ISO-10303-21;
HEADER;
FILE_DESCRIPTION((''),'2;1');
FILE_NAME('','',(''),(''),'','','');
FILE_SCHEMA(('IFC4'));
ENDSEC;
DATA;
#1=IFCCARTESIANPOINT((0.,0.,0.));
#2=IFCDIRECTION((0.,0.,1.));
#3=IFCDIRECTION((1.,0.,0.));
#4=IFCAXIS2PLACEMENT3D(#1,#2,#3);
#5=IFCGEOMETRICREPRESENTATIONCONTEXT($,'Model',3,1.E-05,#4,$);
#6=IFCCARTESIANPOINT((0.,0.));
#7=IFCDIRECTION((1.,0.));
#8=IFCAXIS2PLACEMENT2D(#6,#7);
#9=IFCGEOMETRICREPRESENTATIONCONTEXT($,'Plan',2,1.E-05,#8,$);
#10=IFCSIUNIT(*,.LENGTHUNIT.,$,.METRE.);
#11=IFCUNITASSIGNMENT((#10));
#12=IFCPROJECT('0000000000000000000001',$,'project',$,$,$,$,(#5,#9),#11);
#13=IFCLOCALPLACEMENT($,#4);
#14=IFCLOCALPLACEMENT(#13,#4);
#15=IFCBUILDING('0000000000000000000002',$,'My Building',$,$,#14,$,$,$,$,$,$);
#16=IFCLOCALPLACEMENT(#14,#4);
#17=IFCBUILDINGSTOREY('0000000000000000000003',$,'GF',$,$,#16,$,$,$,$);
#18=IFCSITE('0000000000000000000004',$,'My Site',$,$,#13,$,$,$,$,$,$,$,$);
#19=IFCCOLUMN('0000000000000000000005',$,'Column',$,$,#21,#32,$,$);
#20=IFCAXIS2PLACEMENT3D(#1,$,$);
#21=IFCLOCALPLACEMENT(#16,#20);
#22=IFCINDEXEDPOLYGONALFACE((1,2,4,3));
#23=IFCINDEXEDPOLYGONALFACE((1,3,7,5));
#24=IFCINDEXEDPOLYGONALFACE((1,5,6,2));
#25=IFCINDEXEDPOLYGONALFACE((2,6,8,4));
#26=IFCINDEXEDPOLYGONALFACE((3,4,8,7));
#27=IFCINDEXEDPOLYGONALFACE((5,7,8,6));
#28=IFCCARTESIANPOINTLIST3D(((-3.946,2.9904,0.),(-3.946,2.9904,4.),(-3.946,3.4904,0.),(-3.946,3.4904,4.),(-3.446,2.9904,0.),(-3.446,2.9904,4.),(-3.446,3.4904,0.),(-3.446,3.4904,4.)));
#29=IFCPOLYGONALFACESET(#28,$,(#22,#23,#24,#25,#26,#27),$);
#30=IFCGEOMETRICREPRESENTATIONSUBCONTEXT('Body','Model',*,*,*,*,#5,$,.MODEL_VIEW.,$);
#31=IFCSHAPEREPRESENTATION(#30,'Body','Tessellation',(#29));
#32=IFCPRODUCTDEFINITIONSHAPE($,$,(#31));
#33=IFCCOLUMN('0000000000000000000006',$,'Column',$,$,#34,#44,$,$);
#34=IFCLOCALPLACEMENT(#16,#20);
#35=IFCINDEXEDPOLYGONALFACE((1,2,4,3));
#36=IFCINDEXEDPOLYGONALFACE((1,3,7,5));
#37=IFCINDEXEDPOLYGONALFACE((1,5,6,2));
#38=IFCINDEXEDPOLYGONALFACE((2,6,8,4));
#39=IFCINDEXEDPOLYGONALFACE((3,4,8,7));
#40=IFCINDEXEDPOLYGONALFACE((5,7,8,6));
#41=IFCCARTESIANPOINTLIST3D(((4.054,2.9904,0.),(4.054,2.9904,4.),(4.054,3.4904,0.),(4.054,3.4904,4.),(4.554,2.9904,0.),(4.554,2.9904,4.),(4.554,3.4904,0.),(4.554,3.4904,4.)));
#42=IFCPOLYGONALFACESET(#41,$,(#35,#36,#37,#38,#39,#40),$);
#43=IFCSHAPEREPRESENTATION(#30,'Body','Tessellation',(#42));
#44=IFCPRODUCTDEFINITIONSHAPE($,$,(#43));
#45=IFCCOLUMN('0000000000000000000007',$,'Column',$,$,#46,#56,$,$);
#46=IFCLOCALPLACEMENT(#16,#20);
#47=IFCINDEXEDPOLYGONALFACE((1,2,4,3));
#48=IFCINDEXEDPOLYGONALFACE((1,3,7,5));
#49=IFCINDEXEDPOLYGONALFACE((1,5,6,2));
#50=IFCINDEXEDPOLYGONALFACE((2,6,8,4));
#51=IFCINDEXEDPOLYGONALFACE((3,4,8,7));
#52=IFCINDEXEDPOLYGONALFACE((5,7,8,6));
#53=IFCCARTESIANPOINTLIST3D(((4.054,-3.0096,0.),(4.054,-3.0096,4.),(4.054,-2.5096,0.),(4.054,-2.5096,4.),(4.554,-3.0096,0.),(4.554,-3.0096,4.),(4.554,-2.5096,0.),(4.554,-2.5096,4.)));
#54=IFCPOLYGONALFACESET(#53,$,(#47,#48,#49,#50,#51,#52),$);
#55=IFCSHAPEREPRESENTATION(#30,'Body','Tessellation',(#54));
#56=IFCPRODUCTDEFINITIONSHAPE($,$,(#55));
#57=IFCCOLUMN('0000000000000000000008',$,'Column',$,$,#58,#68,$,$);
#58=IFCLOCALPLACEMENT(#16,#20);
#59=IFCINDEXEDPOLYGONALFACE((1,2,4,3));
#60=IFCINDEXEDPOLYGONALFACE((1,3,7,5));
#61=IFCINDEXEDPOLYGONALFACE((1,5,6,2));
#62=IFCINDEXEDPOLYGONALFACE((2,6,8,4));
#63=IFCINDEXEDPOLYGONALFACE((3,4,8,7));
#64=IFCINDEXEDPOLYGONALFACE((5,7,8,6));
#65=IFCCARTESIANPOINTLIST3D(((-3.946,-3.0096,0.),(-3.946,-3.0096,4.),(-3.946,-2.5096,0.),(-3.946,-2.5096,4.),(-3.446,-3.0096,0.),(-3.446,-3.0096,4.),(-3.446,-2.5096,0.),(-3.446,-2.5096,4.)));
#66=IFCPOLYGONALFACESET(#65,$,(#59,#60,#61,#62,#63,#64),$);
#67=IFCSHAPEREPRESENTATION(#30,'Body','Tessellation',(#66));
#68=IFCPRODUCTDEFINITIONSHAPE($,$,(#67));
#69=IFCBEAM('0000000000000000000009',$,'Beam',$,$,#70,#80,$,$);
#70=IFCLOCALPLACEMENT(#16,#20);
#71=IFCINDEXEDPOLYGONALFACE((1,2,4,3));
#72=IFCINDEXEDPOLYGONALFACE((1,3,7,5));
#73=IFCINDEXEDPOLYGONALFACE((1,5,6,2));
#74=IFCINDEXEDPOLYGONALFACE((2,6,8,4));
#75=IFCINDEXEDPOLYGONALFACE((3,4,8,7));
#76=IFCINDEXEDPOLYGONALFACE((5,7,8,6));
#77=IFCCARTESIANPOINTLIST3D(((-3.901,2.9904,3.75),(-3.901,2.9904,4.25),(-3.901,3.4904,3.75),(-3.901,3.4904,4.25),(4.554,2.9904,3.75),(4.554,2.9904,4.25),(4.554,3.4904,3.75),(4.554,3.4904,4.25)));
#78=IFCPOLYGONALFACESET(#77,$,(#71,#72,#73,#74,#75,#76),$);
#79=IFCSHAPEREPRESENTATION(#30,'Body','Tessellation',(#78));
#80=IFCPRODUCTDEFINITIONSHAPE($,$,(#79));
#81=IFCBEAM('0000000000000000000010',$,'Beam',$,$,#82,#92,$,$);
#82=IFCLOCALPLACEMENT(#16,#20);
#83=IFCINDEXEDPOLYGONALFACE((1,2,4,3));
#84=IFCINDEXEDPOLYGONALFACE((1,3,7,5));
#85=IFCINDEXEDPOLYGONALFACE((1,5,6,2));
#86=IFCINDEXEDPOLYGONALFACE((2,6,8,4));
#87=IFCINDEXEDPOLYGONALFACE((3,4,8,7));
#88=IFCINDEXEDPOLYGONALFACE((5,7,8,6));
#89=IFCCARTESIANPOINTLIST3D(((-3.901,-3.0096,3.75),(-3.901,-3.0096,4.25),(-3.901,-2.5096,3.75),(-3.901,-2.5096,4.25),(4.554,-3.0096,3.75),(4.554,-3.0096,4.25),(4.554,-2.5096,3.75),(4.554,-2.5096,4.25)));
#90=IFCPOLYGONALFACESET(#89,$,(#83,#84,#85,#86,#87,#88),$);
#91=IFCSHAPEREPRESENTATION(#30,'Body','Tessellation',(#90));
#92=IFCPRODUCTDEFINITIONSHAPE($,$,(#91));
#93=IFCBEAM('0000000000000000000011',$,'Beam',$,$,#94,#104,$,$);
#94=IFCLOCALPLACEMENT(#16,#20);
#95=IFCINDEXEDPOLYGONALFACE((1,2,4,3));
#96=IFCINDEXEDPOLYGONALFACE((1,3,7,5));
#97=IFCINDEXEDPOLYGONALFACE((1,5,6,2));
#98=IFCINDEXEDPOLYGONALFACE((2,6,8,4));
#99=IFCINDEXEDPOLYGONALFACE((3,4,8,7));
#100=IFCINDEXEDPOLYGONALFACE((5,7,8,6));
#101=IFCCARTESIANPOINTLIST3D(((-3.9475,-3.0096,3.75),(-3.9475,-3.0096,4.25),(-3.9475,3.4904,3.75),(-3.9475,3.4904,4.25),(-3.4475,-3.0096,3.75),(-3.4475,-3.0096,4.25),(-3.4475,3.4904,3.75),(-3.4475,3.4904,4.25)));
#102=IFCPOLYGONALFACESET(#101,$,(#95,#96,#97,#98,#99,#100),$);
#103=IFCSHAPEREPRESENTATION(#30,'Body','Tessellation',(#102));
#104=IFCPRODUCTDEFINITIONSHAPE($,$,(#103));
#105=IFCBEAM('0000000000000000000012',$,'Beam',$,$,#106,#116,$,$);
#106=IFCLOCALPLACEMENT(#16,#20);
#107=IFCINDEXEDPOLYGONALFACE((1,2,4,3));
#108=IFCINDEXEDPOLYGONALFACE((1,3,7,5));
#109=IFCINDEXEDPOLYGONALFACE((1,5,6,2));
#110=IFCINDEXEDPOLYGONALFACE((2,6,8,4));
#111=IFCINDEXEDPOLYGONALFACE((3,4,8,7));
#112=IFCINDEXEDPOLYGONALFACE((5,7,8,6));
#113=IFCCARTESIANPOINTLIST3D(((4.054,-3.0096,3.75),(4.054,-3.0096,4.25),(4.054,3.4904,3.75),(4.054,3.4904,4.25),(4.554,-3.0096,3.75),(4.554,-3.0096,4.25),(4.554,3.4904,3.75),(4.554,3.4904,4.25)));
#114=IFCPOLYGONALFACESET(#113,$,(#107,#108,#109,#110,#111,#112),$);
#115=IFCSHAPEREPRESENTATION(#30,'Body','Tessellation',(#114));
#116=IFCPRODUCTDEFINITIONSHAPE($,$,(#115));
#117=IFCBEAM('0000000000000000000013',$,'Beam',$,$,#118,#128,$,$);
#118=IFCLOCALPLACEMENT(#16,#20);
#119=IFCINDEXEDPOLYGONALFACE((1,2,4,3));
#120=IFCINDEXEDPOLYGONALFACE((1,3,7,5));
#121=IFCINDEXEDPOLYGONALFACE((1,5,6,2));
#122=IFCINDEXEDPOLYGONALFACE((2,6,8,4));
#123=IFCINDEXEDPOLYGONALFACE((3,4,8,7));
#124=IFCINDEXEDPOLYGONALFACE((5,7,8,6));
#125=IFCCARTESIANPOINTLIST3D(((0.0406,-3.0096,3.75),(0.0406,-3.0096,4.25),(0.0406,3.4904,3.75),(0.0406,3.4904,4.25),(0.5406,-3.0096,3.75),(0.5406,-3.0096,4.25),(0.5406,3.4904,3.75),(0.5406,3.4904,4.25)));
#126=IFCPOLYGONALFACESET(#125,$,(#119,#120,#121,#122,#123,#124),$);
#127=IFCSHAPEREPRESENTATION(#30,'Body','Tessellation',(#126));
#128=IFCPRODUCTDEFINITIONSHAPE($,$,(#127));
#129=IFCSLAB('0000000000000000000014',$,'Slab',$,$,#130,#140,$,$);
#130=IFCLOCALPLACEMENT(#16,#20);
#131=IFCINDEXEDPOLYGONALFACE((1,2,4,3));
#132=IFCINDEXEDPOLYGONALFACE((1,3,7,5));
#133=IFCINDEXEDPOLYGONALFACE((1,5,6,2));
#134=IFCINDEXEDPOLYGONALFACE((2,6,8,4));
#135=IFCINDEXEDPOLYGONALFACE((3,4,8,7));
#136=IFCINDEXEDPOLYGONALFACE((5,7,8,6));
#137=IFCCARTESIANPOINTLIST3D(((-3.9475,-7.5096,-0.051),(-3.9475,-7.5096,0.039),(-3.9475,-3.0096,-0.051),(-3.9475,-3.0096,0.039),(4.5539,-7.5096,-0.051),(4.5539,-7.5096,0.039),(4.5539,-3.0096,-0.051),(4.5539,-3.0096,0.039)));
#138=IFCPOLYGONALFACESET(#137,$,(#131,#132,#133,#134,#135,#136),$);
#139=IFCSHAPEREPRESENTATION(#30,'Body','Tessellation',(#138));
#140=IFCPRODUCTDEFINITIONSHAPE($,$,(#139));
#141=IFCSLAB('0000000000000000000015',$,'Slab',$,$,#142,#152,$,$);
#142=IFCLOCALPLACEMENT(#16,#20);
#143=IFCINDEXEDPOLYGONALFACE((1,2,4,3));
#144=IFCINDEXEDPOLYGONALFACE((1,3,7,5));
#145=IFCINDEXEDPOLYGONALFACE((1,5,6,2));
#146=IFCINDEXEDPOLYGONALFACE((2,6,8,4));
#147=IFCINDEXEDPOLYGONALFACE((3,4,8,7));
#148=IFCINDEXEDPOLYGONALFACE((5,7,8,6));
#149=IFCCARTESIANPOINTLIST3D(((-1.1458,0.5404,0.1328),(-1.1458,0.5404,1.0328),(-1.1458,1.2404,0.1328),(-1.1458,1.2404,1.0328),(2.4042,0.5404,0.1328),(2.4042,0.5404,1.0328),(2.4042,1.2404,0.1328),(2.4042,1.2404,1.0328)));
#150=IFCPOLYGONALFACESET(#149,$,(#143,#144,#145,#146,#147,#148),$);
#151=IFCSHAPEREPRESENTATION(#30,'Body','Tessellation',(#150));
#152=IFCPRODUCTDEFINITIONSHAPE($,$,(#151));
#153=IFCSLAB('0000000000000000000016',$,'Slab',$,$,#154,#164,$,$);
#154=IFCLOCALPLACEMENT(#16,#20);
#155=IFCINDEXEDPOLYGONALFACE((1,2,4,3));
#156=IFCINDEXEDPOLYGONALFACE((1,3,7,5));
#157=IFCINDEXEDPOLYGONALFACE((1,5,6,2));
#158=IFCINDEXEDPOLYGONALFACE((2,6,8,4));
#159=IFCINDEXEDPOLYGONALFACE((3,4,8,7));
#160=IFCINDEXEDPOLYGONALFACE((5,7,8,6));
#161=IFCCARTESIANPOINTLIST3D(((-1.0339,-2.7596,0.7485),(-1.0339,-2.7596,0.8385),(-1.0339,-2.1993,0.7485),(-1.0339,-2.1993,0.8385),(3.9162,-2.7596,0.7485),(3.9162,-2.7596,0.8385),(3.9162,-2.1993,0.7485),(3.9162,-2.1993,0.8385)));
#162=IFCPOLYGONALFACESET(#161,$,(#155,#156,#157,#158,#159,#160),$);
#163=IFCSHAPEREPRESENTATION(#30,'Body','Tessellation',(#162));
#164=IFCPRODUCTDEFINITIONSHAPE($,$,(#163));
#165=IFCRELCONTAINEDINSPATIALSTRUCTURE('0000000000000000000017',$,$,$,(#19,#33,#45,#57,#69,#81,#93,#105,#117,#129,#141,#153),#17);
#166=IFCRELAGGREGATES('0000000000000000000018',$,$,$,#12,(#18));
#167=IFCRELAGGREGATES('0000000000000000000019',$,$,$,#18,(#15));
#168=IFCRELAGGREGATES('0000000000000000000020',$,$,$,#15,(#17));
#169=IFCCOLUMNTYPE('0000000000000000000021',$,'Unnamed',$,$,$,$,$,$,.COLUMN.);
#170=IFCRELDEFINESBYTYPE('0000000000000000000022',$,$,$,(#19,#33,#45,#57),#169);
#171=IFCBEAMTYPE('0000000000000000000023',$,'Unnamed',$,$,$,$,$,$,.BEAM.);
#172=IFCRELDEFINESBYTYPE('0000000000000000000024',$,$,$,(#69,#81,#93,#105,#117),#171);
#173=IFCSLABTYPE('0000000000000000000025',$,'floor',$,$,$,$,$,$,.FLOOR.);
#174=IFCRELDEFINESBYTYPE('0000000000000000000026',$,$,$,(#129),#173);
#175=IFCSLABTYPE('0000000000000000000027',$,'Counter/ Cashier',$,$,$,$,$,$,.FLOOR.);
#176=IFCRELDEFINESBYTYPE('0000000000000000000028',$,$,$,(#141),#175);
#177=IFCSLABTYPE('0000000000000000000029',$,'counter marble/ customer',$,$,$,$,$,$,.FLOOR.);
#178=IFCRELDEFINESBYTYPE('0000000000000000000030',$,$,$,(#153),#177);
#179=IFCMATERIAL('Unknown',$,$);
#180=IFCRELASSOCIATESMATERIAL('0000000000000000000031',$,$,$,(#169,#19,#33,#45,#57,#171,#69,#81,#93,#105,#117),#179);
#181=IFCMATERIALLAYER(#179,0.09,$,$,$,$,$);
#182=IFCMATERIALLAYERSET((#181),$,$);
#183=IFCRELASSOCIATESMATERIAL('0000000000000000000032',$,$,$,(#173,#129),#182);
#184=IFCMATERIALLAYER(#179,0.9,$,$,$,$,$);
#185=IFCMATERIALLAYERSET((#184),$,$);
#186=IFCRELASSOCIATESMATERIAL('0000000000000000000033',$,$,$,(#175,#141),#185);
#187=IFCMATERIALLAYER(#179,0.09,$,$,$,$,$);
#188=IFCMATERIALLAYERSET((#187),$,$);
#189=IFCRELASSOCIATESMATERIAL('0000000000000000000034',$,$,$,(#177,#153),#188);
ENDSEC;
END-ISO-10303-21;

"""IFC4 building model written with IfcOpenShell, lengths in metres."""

from ifc_helpers import new_model, si_unit, frame, origin_with_axes, origin_2d_with_axis, place, context, subcontext, project, spatial, indexed_curve, rectangle, outline, extrude, material, layer, layer_set, layer_usage, material_profile, profile_set, profile_usage, type_object, element, save


model = new_model("IFC4")

# Units and contexts
model_context = context("Model", 3, precision=1e-05, world=origin_with_axes())
plan_context = context("Plan", 2, precision=1e-05, world=origin_2d_with_axis())
body_context_1 = subcontext(model_context, "Body", "Model", "MODEL_VIEW")
ifc_project = project(units=[si_unit("LENGTHUNIT", "METRE")], contexts=[model_context, plan_context])

# Site, building, storey
site_placement = place(None, origin_with_axes())
site = spatial("IfcSite", under=ifc_project, at=site_placement, Name="My Site")
building_placement = place(site_placement, origin_with_axes())
building = spatial("IfcBuilding", under=site, at=building_placement, Name="My Building")
storey_placement = place(building_placement, origin_with_axes())
storey = spatial("IfcBuildingStorey", under=building, at=storey_placement, Name="GF")

# Columns
ifc_material = material(Name="Unknown")
ifc_material_profile_1 = material_profile(ifc_material, rectangle(XDim=0.5, YDim=0.5))
ifc_profile_set_1 = profile_set([ifc_material_profile_1])
ifc_profile_usage_1 = profile_usage(ifc_profile_set_1, cardinal=5)
column_type = type_object("IfcColumnType", Name="Unnamed", PredefinedType="COLUMN", material=ifc_profile_set_1)
column_1_placement = place(storey_placement, frame((-3.696, 3.2404, 0.0), z_axis=(0.0, 0.0, 1.0), x_axis=(1.0, 0.0, 0.0)))
element("IfcColumn", 1, at=column_1_placement, inside=storey, type_object=column_type, material=ifc_profile_usage_1, Name="Column", context=body_context_1, shape_type="SweptSolid", body=[
    extrude(rectangle(XDim=0.5, YDim=0.5), origin_with_axes(), (0.0, 0.0, 1.0), 4.0),
])
ifc_profile_usage_2 = profile_usage(ifc_profile_set_1, cardinal=5)
column_2_placement = place(storey_placement, frame((4.304, 3.2404, 0.0), z_axis=(0.0, 0.0, 1.0), x_axis=(1.0, 0.0, 0.0)))
element("IfcColumn", 2, at=column_2_placement, inside=storey, type_object=column_type, material=ifc_profile_usage_2, Name="Column", context=body_context_1, shape_type="SweptSolid", body=[
    extrude(rectangle(XDim=0.5, YDim=0.5), origin_with_axes(), (0.0, 0.0, 1.0), 4.0),
])
ifc_profile_usage_3 = profile_usage(ifc_profile_set_1, cardinal=5)
column_3_placement = place(storey_placement, frame((4.304, -2.7596, 0.0), z_axis=(0.0, 0.0, 1.0), x_axis=(1.0, 0.0, 0.0)))
element("IfcColumn", 3, at=column_3_placement, inside=storey, type_object=column_type, material=ifc_profile_usage_3, Name="Column", context=body_context_1, shape_type="SweptSolid", body=[
    extrude(rectangle(XDim=0.5, YDim=0.5), origin_with_axes(), (0.0, 0.0, 1.0), 4.0),
])
ifc_profile_usage_4 = profile_usage(ifc_profile_set_1, cardinal=5)
column_4_placement = place(storey_placement, frame((-3.696, -2.7596, 0.0), z_axis=(0.0, 0.0, 1.0), x_axis=(1.0, 0.0, 0.0)))
element("IfcColumn", 4, at=column_4_placement, inside=storey, type_object=column_type, material=ifc_profile_usage_4, Name="Column", context=body_context_1, shape_type="SweptSolid", body=[
    extrude(rectangle(XDim=0.5, YDim=0.5), origin_with_axes(), (0.0, 0.0, 1.0), 4.0),
])

# Beams
ifc_material_profile_2 = material_profile(ifc_material, rectangle(XDim=0.5, YDim=0.5))
ifc_profile_set_2 = profile_set([ifc_material_profile_2])
ifc_profile_usage_5 = profile_usage(ifc_profile_set_2, cardinal=5)
beam_type = type_object("IfcBeamType", Name="Unnamed", PredefinedType="BEAM", material=ifc_profile_set_2)
beam_1_placement = place(storey_placement, frame((-3.901, 3.2404, 4.0), z_axis=(1.0, 0.0, 0.0), x_axis=(0.0, 1.0, 0.0)))
element("IfcBeam", 5, at=beam_1_placement, inside=storey, type_object=beam_type, material=ifc_profile_usage_5, Name="Beam", context=body_context_1, shape_type="SweptSolid", body=[
    extrude(rectangle(XDim=0.5, YDim=0.5), origin_with_axes(), (0.0, 0.0, 1.0), 8.4549),
])
ifc_profile_usage_6 = profile_usage(ifc_profile_set_2, cardinal=5)
beam_2_placement = place(storey_placement, frame((-3.901, -2.7596, 4.0), z_axis=(1.0, 0.0, 0.0), x_axis=(0.0, 1.0, 0.0)))
element("IfcBeam", 6, at=beam_2_placement, inside=storey, type_object=beam_type, material=ifc_profile_usage_6, Name="Beam", context=body_context_1, shape_type="SweptSolid", body=[
    extrude(rectangle(XDim=0.5, YDim=0.5), origin_with_axes(), (0.0, 0.0, 1.0), 8.4549),
])
ifc_profile_usage_7 = profile_usage(ifc_profile_set_2, cardinal=5)
beam_3_placement = place(storey_placement, frame((-3.6975, 3.4904, 4.0), z_axis=(0.0, -1.0, 0.0), x_axis=(1.0, 0.0, 0.0)))
element("IfcBeam", 7, at=beam_3_placement, inside=storey, type_object=beam_type, material=ifc_profile_usage_7, Name="Beam", context=body_context_1, shape_type="SweptSolid", body=[
    extrude(rectangle(XDim=0.5, YDim=0.5), origin_with_axes(), (0.0, 0.0, 1.0), 6.5),
])
ifc_profile_usage_8 = profile_usage(ifc_profile_set_2, cardinal=5)
beam_4_placement = place(storey_placement, frame((4.304, 3.4904, 4.0), z_axis=(0.0, -1.0, 0.0), x_axis=(1.0, 0.0, 0.0)))
element("IfcBeam", 8, at=beam_4_placement, inside=storey, type_object=beam_type, material=ifc_profile_usage_8, Name="Beam", context=body_context_1, shape_type="SweptSolid", body=[
    extrude(rectangle(XDim=0.5, YDim=0.5), origin_with_axes(), (0.0, 0.0, 1.0), 6.5),
])
ifc_profile_usage_9 = profile_usage(ifc_profile_set_2, cardinal=5)
beam_5_placement = place(storey_placement, frame((0.2906, 3.4904, 4.0), z_axis=(0.0, -1.0, 0.0), x_axis=(1.0, 0.0, 0.0)))
element("IfcBeam", 9, at=beam_5_placement, inside=storey, type_object=beam_type, material=ifc_profile_usage_9, Name="Beam", context=body_context_1, shape_type="SweptSolid", body=[
    extrude(rectangle(XDim=0.5, YDim=0.5), origin_with_axes(), (0.0, 0.0, 1.0), 6.5),
])

# Slabs
ifc_layer_1 = layer(ifc_material, 0.09)
ifc_layer_set_1 = layer_set([ifc_layer_1])
slab_type_1 = type_object("IfcSlabType", Name="floor", PredefinedType="FLOOR", material=ifc_layer_set_1)
ifc_layer_usage_1 = layer_usage(ifc_layer_set_1, "AXIS3", "POSITIVE", -0.09)
slab_1_placement = place(storey_placement, frame((-3.9475, -3.0096, 0.039), z_axis=(0.0, 0.0, 1.0), x_axis=(1.0, 0.0, 0.0)))
element("IfcSlab", 10, at=slab_1_placement, inside=storey, type_object=slab_type_1, material=ifc_layer_usage_1, Name="Slab", context=body_context_1, shape_type="SweptSolid", body=[
    extrude(outline(indexed_curve([(0.0, 0.0), (0.0, -4.5), (8.5014, -4.5), (8.5014, 0.0), (0.0, 0.0)])), frame((0.0, 0.0, -0.09), z_axis=(0.0, 0.0, 1.0), x_axis=(1.0, 0.0, 0.0)), (0.0, 0.0, 1.0), 0.09),
])
ifc_layer_2 = layer(ifc_material, 0.9)
ifc_layer_set_2 = layer_set([ifc_layer_2])
ifc_layer_usage_2 = layer_usage(ifc_layer_set_2, "AXIS3", "POSITIVE", -0.9)
slab_type_2 = type_object("IfcSlabType", Name="Counter/ Cashier", PredefinedType="FLOOR", material=ifc_layer_set_2)
slab_2_placement = place(storey_placement, frame((-1.1458, 1.2404, 1.0328), z_axis=(0.0, 0.0, 1.0), x_axis=(1.0, 0.0, 0.0)))
element("IfcSlab", 11, at=slab_2_placement, inside=storey, type_object=slab_type_2, material=ifc_layer_usage_2, Name="Slab", context=body_context_1, shape_type="SweptSolid", body=[
    extrude(outline(indexed_curve([(0.0, 0.0), (0.0, -0.7), (3.55, -0.7), (3.55, 0.0), (0.0, 0.0)])), frame((0.0, 0.0, -0.9), z_axis=(0.0, 0.0, 1.0), x_axis=(1.0, 0.0, 0.0)), (0.0, 0.0, 1.0), 0.9),
])
ifc_layer_3 = layer(ifc_material, 0.09)
ifc_layer_set_3 = layer_set([ifc_layer_3])
ifc_layer_usage_3 = layer_usage(ifc_layer_set_3, "AXIS3", "POSITIVE", -0.09)
slab_type_3 = type_object("IfcSlabType", Name="counter marble/ customer", PredefinedType="FLOOR", material=ifc_layer_set_3)
slab_3_placement = place(storey_placement, frame((-1.0339, -2.7596, 0.8385), z_axis=(0.0, 0.0, 1.0), x_axis=(1.0, 0.0, 0.0)))
element("IfcSlab", 12, at=slab_3_placement, inside=storey, type_object=slab_type_3, material=ifc_layer_usage_3, Name="Slab", context=body_context_1, shape_type="SweptSolid", body=[
    extrude(outline(indexed_curve([(0.0, 0.0), (0.0, 0.5602), (4.9501, 0.5602), (4.9501, -0.0001), (0.0, 0.0)])), frame((0.0, 0.0, -0.09), z_axis=(0.0, 0.0, 1.0), x_axis=(1.0, 0.0, 0.0)), (0.0, 0.0, 1.0), 0.09),
])

save(model, "model.ifc")
